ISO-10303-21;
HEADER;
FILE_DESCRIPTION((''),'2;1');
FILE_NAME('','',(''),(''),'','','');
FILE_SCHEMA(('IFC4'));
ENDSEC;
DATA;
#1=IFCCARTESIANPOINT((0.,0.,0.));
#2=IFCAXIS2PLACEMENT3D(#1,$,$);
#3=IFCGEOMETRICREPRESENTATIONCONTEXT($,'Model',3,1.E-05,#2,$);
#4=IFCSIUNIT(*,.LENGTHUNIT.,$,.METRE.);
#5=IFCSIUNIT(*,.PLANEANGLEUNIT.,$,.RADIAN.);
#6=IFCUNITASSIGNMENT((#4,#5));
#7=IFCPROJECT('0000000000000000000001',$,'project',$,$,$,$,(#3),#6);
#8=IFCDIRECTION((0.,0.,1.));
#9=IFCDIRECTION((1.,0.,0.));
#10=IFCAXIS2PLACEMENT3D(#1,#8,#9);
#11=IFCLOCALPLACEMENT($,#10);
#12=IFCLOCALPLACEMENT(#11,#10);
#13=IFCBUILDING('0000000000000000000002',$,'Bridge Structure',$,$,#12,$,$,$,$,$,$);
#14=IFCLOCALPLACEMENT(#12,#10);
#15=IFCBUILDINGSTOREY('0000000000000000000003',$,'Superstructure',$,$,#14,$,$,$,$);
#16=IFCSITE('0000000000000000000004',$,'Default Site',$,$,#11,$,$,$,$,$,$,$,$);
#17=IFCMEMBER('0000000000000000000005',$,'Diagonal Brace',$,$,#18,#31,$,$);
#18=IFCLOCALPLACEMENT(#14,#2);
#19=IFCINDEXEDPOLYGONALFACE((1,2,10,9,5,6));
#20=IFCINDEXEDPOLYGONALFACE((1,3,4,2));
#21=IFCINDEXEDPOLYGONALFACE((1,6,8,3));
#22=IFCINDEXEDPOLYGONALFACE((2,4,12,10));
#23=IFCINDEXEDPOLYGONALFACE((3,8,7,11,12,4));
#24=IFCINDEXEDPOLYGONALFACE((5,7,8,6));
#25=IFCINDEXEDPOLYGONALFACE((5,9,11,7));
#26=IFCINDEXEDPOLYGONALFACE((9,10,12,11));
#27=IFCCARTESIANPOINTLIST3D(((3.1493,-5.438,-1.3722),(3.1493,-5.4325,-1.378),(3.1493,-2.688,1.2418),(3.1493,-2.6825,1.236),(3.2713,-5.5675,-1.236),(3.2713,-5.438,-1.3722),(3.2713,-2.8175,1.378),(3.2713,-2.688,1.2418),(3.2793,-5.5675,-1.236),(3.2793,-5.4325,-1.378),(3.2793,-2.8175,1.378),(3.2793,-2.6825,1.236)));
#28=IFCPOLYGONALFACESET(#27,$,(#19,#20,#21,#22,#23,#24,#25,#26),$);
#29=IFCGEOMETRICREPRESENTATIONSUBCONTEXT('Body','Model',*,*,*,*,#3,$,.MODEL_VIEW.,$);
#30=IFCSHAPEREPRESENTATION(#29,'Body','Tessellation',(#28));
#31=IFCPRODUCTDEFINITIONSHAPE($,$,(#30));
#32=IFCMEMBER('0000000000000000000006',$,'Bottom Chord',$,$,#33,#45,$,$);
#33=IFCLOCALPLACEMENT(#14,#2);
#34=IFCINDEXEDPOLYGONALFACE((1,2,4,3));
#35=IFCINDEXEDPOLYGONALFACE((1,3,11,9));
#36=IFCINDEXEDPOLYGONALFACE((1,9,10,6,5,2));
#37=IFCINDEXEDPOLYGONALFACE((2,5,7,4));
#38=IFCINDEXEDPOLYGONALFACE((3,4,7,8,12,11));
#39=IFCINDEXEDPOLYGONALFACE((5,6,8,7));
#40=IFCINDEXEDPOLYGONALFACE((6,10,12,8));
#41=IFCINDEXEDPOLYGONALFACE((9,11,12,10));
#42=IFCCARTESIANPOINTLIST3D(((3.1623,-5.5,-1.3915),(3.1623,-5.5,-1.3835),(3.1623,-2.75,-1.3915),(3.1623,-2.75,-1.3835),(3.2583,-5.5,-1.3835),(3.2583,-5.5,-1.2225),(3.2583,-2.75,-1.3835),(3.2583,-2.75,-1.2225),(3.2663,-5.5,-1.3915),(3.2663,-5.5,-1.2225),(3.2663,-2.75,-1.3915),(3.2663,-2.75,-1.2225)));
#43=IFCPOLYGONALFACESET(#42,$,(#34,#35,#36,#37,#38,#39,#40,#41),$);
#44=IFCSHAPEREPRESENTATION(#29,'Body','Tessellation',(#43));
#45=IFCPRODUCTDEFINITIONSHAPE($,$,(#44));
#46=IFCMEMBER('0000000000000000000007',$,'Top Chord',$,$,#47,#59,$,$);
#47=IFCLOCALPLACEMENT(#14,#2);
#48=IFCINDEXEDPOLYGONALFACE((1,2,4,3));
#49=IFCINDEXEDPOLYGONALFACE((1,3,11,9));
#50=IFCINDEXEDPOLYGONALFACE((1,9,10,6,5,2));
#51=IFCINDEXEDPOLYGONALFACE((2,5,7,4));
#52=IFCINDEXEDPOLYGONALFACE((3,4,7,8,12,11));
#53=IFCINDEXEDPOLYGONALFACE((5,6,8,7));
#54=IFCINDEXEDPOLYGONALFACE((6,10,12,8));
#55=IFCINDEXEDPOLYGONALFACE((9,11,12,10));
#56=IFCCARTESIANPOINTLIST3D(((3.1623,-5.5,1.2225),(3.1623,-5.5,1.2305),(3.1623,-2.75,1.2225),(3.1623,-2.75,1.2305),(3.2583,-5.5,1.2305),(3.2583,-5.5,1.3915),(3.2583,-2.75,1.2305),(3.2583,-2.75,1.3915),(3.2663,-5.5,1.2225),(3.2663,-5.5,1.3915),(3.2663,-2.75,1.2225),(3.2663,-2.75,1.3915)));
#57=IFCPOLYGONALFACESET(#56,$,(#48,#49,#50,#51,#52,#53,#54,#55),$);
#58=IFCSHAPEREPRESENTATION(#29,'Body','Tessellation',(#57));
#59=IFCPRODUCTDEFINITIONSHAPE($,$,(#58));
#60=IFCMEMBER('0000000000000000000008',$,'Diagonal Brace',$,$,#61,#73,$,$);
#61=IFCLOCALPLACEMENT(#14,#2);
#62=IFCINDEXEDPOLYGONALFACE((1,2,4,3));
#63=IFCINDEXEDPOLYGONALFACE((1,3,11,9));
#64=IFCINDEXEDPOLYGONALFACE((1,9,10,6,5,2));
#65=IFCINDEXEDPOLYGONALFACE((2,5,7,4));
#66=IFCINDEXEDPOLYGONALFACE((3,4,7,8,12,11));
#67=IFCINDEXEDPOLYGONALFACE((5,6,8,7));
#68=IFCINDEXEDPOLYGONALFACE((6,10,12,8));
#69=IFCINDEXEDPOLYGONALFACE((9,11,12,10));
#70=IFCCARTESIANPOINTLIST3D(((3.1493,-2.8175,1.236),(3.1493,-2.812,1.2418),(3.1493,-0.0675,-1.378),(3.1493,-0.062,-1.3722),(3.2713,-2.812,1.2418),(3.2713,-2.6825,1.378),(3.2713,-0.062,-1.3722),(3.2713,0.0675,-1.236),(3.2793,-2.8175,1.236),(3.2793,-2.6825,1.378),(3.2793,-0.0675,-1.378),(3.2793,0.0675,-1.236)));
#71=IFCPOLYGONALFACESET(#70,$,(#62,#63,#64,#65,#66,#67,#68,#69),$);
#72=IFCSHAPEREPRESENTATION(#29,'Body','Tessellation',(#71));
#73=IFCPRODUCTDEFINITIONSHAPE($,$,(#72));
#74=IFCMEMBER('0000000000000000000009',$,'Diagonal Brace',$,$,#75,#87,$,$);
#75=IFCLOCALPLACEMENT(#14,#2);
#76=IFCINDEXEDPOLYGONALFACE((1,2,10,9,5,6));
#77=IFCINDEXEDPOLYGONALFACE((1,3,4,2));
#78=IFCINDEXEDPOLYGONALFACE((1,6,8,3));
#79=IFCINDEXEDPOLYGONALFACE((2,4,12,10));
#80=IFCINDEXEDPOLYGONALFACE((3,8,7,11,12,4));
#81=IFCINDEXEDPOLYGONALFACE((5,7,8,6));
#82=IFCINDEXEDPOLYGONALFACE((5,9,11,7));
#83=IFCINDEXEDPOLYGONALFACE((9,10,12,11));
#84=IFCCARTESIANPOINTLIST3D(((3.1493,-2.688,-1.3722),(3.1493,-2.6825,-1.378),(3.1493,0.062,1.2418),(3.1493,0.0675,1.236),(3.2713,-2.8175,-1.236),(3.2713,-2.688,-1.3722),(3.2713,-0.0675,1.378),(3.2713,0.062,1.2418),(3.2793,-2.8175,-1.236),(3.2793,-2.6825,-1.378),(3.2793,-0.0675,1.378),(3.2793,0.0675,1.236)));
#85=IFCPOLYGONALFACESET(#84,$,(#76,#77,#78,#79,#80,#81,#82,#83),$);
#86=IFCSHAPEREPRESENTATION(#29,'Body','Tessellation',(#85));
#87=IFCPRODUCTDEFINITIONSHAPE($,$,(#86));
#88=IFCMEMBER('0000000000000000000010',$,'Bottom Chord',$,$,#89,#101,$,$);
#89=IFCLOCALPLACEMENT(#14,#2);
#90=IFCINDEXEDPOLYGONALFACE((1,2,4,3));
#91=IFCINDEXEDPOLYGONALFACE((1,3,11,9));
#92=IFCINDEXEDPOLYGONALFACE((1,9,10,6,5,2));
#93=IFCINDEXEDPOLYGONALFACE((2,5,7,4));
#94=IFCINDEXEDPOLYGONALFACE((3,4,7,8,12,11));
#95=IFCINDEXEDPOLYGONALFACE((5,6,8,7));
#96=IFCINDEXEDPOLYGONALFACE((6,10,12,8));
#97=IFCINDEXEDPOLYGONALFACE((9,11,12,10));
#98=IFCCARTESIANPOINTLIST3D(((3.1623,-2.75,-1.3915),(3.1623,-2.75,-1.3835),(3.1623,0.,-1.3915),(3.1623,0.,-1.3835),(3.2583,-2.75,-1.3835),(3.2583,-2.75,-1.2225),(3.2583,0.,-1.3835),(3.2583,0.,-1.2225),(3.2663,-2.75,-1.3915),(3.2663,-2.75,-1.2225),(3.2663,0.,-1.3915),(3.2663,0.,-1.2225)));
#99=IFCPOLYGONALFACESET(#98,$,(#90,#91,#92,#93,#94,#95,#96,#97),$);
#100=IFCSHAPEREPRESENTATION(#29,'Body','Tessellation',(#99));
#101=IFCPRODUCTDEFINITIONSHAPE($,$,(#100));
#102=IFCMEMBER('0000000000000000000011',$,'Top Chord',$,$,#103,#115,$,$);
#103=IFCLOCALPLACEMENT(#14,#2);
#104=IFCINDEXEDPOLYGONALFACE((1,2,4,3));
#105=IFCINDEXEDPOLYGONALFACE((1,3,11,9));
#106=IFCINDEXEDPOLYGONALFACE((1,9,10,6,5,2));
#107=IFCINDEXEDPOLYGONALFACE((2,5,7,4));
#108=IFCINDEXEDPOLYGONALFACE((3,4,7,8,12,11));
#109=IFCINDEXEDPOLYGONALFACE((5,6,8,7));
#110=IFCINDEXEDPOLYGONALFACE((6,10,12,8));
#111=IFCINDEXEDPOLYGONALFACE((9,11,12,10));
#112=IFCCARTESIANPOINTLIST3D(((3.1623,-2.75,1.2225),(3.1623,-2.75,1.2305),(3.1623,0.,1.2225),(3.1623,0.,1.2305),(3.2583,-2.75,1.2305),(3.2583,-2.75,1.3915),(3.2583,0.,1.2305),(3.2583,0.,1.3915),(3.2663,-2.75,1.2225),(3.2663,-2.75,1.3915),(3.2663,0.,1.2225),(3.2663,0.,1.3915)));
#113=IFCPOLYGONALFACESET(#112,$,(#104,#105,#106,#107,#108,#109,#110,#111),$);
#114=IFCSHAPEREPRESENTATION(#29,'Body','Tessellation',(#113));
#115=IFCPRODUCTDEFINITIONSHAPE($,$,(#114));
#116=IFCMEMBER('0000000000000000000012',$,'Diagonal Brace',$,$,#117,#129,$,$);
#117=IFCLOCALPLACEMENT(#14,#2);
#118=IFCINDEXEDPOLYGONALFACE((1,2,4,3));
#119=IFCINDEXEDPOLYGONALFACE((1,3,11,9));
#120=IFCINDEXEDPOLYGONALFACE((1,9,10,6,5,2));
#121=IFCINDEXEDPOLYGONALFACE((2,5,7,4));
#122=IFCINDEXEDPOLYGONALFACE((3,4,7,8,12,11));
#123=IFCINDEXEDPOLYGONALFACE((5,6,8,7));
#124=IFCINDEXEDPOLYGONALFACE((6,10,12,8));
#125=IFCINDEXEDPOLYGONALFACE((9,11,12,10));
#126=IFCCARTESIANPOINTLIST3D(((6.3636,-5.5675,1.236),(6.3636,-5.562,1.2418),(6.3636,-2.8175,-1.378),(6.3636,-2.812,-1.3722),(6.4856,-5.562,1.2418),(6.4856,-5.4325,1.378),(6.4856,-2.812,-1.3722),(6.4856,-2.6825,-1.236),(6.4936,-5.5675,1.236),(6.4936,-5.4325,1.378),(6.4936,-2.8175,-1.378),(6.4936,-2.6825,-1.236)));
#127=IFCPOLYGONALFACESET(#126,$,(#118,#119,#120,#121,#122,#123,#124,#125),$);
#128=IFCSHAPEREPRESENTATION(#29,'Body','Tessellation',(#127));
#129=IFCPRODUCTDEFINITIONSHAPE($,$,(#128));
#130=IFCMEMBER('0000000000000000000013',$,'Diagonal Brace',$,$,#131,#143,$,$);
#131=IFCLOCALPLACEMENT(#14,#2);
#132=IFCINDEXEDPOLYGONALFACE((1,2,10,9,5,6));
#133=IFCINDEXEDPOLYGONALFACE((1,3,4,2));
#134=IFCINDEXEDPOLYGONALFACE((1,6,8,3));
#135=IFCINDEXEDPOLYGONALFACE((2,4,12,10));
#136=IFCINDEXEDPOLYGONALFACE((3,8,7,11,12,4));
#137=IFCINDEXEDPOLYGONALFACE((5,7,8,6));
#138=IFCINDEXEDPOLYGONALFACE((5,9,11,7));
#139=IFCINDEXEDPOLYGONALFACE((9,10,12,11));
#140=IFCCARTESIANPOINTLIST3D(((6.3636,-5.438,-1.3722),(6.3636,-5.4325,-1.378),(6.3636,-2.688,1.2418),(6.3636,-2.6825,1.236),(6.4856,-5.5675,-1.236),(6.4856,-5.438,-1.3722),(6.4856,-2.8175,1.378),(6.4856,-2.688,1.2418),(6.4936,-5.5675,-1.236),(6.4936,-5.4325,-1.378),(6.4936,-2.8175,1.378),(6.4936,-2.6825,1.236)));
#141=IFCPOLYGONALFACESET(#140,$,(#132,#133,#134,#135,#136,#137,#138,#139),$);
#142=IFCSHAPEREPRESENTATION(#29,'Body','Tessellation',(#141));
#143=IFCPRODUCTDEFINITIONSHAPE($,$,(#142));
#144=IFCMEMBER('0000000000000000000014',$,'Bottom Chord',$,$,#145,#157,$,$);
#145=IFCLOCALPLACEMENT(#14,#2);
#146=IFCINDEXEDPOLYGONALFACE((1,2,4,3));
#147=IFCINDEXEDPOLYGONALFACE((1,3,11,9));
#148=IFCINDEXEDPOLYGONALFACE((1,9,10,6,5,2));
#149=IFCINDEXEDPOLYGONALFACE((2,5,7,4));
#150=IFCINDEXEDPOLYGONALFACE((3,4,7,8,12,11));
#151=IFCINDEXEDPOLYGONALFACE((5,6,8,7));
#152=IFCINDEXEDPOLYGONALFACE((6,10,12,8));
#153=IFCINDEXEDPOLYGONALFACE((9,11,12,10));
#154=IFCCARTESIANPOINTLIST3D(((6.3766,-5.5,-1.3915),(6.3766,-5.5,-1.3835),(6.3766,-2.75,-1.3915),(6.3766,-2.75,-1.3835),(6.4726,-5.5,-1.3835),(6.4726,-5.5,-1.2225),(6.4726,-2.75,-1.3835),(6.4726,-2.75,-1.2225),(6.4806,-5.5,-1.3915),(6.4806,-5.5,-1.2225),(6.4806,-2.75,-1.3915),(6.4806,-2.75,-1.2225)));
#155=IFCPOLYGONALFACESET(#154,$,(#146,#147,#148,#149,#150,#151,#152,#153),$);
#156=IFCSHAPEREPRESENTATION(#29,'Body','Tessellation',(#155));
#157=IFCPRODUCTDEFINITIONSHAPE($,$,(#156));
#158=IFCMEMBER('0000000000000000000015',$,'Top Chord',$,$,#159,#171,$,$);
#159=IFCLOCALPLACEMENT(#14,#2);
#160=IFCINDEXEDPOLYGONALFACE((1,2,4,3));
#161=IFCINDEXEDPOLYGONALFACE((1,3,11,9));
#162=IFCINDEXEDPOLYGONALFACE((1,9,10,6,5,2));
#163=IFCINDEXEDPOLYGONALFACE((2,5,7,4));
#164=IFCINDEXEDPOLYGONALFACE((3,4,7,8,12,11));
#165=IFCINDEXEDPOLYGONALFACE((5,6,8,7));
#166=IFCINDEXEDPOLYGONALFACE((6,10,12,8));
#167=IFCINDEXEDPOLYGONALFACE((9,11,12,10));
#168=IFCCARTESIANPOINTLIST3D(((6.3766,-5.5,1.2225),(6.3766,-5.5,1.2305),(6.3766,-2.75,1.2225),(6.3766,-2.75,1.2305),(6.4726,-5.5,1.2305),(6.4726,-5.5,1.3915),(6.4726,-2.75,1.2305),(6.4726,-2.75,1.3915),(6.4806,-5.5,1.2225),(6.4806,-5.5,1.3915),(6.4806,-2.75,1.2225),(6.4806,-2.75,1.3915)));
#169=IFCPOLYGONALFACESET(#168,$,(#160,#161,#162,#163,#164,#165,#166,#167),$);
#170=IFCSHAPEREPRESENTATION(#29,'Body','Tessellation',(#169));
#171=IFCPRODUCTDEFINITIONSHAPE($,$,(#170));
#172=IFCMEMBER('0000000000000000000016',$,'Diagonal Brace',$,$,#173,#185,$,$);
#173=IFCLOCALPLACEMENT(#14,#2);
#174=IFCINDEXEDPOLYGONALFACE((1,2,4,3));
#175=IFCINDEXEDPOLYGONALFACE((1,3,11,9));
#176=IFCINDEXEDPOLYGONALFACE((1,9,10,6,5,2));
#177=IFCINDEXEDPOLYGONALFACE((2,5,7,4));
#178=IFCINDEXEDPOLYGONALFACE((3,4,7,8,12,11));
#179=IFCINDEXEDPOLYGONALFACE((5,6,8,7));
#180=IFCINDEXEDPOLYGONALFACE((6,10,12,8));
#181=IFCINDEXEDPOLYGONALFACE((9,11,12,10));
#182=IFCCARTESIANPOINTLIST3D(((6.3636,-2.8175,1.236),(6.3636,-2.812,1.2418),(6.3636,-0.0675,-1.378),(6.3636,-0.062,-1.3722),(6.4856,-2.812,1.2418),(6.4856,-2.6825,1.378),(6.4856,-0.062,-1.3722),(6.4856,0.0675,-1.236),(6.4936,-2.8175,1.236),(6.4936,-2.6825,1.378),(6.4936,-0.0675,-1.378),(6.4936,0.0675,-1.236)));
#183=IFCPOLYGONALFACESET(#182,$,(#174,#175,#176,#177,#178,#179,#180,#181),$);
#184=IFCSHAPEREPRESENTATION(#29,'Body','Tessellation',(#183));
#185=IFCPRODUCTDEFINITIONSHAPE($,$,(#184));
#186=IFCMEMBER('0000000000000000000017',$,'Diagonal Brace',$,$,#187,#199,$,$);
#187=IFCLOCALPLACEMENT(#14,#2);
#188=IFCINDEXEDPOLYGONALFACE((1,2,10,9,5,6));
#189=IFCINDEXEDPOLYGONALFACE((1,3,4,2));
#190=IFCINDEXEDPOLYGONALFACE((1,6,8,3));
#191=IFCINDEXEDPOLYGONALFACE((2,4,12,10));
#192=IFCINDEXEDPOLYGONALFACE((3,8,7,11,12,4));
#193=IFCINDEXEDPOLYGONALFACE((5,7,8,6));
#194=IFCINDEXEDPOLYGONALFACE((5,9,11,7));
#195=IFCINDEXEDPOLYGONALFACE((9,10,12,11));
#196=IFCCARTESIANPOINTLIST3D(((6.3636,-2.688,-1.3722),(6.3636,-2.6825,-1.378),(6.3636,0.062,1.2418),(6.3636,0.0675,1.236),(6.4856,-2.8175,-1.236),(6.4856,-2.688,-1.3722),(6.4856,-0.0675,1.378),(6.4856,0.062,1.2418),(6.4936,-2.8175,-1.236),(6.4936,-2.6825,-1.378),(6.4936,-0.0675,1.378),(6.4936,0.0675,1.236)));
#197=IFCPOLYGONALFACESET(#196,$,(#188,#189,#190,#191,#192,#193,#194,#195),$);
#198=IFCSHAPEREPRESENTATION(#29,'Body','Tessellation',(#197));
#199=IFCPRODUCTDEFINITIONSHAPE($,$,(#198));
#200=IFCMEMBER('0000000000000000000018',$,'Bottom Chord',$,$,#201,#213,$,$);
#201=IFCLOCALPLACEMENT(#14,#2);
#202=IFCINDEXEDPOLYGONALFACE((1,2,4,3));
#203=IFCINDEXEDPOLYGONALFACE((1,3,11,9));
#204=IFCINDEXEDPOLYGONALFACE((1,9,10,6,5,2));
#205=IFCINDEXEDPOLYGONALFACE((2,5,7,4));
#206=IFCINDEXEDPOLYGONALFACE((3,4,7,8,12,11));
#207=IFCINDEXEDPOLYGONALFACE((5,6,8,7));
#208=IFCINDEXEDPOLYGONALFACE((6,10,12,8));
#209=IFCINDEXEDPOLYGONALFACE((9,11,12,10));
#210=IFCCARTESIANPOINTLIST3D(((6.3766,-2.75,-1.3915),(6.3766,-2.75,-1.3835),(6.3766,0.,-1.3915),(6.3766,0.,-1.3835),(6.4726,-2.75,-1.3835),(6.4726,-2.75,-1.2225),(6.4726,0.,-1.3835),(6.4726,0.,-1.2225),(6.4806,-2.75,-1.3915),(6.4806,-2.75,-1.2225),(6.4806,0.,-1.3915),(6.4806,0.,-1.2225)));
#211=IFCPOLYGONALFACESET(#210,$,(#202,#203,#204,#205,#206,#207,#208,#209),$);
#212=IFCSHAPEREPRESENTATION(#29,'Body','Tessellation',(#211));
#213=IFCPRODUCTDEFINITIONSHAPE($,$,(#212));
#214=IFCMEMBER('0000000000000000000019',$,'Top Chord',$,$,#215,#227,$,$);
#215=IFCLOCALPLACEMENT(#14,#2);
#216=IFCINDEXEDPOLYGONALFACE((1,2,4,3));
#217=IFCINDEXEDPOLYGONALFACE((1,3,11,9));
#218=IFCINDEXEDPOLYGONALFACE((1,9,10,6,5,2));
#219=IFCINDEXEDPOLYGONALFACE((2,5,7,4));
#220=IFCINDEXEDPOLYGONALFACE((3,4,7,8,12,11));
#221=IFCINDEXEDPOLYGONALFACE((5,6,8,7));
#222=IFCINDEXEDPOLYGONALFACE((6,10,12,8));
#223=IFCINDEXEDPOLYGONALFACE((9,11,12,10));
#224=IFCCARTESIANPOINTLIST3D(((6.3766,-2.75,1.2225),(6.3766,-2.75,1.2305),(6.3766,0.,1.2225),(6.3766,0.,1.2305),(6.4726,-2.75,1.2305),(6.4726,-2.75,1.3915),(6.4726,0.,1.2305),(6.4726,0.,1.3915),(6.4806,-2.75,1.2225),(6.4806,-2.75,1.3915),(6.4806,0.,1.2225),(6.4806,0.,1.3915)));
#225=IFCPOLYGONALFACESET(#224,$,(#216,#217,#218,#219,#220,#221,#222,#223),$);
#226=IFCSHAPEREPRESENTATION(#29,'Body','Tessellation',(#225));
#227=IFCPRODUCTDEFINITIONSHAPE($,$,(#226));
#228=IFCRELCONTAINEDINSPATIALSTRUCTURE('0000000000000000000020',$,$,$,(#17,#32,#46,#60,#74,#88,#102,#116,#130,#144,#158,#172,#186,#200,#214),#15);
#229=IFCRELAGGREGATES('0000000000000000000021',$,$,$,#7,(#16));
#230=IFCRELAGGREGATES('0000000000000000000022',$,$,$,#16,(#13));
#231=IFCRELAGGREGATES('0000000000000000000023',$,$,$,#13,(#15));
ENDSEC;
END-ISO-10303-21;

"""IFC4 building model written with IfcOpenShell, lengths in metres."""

from ifc_helpers import new_model, si_unit, frame, origin, origin_with_axes, origin_2d_with_axis, place, context, subcontext, project, spatial, l_section, extrude, element, save


model = new_model("IFC4")

# Units and contexts
model_context = context("Model", 3, precision=1e-05, world=origin())
body_context = subcontext(model_context, "Body", "Model", "MODEL_VIEW")
ifc_project = project(units=[si_unit("LENGTHUNIT", "METRE"), si_unit("PLANEANGLEUNIT", "RADIAN")], contexts=[model_context])

# Site, building, storey
site_placement = place(None, origin_with_axes())
site = spatial("IfcSite", under=ifc_project, at=site_placement, Name="Default Site")
building_placement = place(site_placement, origin_with_axes())
building = spatial("IfcBuilding", under=site, at=building_placement, Name="Bridge Structure")
storey_placement = place(building_placement, origin_with_axes())
storey = spatial("IfcBuildingStorey", under=building, at=storey_placement, Name="Superstructure")

# Members
member_placement = place(storey_placement, frame((3.2143, -5.5, -1.307), z_axis=(0.0, 0.724802, 0.688957), x_axis=(-1.0, 0.0, 0.0)))
element("IfcMember", 1, at=member_placement, inside=storey, Name="Diagonal Brace", context=body_context, shape_type="SweptSolid", body=[
    extrude(l_section(Depth=0.196, Width=0.13, Thickness=0.008, at=origin_2d_with_axis()), origin_with_axes(), (0.0, 0.0, 1.0), 3.7941),
])
for number, where, z_axis, x_axis, name in (
    (2, (3.2143, -5.5, -1.307), (0.0, 1.0, 0.0), (-1.0, 0.0, 0.0), "Bottom Chord"),
    (3, (3.2143, -5.5, 1.307), (0.0, 1.0, 0.0), (-1.0, 0.0, 0.0), "Top Chord"),
):
    element("IfcMember", number, at=place(storey_placement, frame(where, z_axis=z_axis, x_axis=x_axis)), inside=storey, Name=name, context=body_context, shape_type="SweptSolid", body=[
        extrude(l_section(Depth=0.169, Width=0.104, Thickness=0.008, at=origin_2d_with_axis()), origin_with_axes(), (0.0, 0.0, 1.0), 2.75),
    ])
for number, where, z_axis, x_axis, name in (
    (4, (3.2143, -2.75, 1.307), (0.0, 0.724802, -0.688957), (-1.0, 0.0, 0.0), "Diagonal Brace"),
    (5, (3.2143, -2.75, -1.307), (0.0, 0.724802, 0.688957), (-1.0, 0.0, 0.0), "Diagonal Brace"),
):
    element("IfcMember", number, at=place(storey_placement, frame(where, z_axis=z_axis, x_axis=x_axis)), inside=storey, Name=name, context=body_context, shape_type="SweptSolid", body=[
        extrude(l_section(Depth=0.196, Width=0.13, Thickness=0.008, at=origin_2d_with_axis()), origin_with_axes(), (0.0, 0.0, 1.0), 3.7941),
    ])
for number, where, z_axis, x_axis, name in (
    (6, (3.2143, -2.75, -1.307), (0.0, 1.0, 0.0), (-1.0, 0.0, 0.0), "Bottom Chord"),
    (7, (3.2143, -2.75, 1.307), (0.0, 1.0, 0.0), (-1.0, 0.0, 0.0), "Top Chord"),
):
    element("IfcMember", number, at=place(storey_placement, frame(where, z_axis=z_axis, x_axis=x_axis)), inside=storey, Name=name, context=body_context, shape_type="SweptSolid", body=[
        extrude(l_section(Depth=0.169, Width=0.104, Thickness=0.008, at=origin_2d_with_axis()), origin_with_axes(), (0.0, 0.0, 1.0), 2.75),
    ])
for number, where, z_axis, x_axis, name in (
    (8, (6.4286, -5.5, 1.307), (0.0, 0.724802, -0.688957), (-1.0, 0.0, 0.0), "Diagonal Brace"),
    (9, (6.4286, -5.5, -1.307), (0.0, 0.724802, 0.688957), (-1.0, 0.0, 0.0), "Diagonal Brace"),
):
    element("IfcMember", number, at=place(storey_placement, frame(where, z_axis=z_axis, x_axis=x_axis)), inside=storey, Name=name, context=body_context, shape_type="SweptSolid", body=[
        extrude(l_section(Depth=0.196, Width=0.13, Thickness=0.008, at=origin_2d_with_axis()), origin_with_axes(), (0.0, 0.0, 1.0), 3.7941),
    ])
for number, where, z_axis, x_axis, name in (
    (10, (6.4286, -5.5, -1.307), (0.0, 1.0, 0.0), (-1.0, 0.0, 0.0), "Bottom Chord"),
    (11, (6.4286, -5.5, 1.307), (0.0, 1.0, 0.0), (-1.0, 0.0, 0.0), "Top Chord"),
):
    element("IfcMember", number, at=place(storey_placement, frame(where, z_axis=z_axis, x_axis=x_axis)), inside=storey, Name=name, context=body_context, shape_type="SweptSolid", body=[
        extrude(l_section(Depth=0.169, Width=0.104, Thickness=0.008, at=origin_2d_with_axis()), origin_with_axes(), (0.0, 0.0, 1.0), 2.75),
    ])
for number, where, z_axis, x_axis, name in (
    (12, (6.4286, -2.75, 1.307), (0.0, 0.724802, -0.688957), (-1.0, 0.0, 0.0), "Diagonal Brace"),
    (13, (6.4286, -2.75, -1.307), (0.0, 0.724802, 0.688957), (-1.0, 0.0, 0.0), "Diagonal Brace"),
):
    element("IfcMember", number, at=place(storey_placement, frame(where, z_axis=z_axis, x_axis=x_axis)), inside=storey, Name=name, context=body_context, shape_type="SweptSolid", body=[
        extrude(l_section(Depth=0.196, Width=0.13, Thickness=0.008, at=origin_2d_with_axis()), origin_with_axes(), (0.0, 0.0, 1.0), 3.7941),
    ])
for number, where, z_axis, x_axis, name in (
    (14, (6.4286, -2.75, -1.307), (0.0, 1.0, 0.0), (-1.0, 0.0, 0.0), "Bottom Chord"),
    (15, (6.4286, -2.75, 1.307), (0.0, 1.0, 0.0), (-1.0, 0.0, 0.0), "Top Chord"),
):
    element("IfcMember", number, at=place(storey_placement, frame(where, z_axis=z_axis, x_axis=x_axis)), inside=storey, Name=name, context=body_context, shape_type="SweptSolid", body=[
        extrude(l_section(Depth=0.169, Width=0.104, Thickness=0.008, at=origin_2d_with_axis()), origin_with_axes(), (0.0, 0.0, 1.0), 2.75),
    ])

save(model, "model.ifc")
